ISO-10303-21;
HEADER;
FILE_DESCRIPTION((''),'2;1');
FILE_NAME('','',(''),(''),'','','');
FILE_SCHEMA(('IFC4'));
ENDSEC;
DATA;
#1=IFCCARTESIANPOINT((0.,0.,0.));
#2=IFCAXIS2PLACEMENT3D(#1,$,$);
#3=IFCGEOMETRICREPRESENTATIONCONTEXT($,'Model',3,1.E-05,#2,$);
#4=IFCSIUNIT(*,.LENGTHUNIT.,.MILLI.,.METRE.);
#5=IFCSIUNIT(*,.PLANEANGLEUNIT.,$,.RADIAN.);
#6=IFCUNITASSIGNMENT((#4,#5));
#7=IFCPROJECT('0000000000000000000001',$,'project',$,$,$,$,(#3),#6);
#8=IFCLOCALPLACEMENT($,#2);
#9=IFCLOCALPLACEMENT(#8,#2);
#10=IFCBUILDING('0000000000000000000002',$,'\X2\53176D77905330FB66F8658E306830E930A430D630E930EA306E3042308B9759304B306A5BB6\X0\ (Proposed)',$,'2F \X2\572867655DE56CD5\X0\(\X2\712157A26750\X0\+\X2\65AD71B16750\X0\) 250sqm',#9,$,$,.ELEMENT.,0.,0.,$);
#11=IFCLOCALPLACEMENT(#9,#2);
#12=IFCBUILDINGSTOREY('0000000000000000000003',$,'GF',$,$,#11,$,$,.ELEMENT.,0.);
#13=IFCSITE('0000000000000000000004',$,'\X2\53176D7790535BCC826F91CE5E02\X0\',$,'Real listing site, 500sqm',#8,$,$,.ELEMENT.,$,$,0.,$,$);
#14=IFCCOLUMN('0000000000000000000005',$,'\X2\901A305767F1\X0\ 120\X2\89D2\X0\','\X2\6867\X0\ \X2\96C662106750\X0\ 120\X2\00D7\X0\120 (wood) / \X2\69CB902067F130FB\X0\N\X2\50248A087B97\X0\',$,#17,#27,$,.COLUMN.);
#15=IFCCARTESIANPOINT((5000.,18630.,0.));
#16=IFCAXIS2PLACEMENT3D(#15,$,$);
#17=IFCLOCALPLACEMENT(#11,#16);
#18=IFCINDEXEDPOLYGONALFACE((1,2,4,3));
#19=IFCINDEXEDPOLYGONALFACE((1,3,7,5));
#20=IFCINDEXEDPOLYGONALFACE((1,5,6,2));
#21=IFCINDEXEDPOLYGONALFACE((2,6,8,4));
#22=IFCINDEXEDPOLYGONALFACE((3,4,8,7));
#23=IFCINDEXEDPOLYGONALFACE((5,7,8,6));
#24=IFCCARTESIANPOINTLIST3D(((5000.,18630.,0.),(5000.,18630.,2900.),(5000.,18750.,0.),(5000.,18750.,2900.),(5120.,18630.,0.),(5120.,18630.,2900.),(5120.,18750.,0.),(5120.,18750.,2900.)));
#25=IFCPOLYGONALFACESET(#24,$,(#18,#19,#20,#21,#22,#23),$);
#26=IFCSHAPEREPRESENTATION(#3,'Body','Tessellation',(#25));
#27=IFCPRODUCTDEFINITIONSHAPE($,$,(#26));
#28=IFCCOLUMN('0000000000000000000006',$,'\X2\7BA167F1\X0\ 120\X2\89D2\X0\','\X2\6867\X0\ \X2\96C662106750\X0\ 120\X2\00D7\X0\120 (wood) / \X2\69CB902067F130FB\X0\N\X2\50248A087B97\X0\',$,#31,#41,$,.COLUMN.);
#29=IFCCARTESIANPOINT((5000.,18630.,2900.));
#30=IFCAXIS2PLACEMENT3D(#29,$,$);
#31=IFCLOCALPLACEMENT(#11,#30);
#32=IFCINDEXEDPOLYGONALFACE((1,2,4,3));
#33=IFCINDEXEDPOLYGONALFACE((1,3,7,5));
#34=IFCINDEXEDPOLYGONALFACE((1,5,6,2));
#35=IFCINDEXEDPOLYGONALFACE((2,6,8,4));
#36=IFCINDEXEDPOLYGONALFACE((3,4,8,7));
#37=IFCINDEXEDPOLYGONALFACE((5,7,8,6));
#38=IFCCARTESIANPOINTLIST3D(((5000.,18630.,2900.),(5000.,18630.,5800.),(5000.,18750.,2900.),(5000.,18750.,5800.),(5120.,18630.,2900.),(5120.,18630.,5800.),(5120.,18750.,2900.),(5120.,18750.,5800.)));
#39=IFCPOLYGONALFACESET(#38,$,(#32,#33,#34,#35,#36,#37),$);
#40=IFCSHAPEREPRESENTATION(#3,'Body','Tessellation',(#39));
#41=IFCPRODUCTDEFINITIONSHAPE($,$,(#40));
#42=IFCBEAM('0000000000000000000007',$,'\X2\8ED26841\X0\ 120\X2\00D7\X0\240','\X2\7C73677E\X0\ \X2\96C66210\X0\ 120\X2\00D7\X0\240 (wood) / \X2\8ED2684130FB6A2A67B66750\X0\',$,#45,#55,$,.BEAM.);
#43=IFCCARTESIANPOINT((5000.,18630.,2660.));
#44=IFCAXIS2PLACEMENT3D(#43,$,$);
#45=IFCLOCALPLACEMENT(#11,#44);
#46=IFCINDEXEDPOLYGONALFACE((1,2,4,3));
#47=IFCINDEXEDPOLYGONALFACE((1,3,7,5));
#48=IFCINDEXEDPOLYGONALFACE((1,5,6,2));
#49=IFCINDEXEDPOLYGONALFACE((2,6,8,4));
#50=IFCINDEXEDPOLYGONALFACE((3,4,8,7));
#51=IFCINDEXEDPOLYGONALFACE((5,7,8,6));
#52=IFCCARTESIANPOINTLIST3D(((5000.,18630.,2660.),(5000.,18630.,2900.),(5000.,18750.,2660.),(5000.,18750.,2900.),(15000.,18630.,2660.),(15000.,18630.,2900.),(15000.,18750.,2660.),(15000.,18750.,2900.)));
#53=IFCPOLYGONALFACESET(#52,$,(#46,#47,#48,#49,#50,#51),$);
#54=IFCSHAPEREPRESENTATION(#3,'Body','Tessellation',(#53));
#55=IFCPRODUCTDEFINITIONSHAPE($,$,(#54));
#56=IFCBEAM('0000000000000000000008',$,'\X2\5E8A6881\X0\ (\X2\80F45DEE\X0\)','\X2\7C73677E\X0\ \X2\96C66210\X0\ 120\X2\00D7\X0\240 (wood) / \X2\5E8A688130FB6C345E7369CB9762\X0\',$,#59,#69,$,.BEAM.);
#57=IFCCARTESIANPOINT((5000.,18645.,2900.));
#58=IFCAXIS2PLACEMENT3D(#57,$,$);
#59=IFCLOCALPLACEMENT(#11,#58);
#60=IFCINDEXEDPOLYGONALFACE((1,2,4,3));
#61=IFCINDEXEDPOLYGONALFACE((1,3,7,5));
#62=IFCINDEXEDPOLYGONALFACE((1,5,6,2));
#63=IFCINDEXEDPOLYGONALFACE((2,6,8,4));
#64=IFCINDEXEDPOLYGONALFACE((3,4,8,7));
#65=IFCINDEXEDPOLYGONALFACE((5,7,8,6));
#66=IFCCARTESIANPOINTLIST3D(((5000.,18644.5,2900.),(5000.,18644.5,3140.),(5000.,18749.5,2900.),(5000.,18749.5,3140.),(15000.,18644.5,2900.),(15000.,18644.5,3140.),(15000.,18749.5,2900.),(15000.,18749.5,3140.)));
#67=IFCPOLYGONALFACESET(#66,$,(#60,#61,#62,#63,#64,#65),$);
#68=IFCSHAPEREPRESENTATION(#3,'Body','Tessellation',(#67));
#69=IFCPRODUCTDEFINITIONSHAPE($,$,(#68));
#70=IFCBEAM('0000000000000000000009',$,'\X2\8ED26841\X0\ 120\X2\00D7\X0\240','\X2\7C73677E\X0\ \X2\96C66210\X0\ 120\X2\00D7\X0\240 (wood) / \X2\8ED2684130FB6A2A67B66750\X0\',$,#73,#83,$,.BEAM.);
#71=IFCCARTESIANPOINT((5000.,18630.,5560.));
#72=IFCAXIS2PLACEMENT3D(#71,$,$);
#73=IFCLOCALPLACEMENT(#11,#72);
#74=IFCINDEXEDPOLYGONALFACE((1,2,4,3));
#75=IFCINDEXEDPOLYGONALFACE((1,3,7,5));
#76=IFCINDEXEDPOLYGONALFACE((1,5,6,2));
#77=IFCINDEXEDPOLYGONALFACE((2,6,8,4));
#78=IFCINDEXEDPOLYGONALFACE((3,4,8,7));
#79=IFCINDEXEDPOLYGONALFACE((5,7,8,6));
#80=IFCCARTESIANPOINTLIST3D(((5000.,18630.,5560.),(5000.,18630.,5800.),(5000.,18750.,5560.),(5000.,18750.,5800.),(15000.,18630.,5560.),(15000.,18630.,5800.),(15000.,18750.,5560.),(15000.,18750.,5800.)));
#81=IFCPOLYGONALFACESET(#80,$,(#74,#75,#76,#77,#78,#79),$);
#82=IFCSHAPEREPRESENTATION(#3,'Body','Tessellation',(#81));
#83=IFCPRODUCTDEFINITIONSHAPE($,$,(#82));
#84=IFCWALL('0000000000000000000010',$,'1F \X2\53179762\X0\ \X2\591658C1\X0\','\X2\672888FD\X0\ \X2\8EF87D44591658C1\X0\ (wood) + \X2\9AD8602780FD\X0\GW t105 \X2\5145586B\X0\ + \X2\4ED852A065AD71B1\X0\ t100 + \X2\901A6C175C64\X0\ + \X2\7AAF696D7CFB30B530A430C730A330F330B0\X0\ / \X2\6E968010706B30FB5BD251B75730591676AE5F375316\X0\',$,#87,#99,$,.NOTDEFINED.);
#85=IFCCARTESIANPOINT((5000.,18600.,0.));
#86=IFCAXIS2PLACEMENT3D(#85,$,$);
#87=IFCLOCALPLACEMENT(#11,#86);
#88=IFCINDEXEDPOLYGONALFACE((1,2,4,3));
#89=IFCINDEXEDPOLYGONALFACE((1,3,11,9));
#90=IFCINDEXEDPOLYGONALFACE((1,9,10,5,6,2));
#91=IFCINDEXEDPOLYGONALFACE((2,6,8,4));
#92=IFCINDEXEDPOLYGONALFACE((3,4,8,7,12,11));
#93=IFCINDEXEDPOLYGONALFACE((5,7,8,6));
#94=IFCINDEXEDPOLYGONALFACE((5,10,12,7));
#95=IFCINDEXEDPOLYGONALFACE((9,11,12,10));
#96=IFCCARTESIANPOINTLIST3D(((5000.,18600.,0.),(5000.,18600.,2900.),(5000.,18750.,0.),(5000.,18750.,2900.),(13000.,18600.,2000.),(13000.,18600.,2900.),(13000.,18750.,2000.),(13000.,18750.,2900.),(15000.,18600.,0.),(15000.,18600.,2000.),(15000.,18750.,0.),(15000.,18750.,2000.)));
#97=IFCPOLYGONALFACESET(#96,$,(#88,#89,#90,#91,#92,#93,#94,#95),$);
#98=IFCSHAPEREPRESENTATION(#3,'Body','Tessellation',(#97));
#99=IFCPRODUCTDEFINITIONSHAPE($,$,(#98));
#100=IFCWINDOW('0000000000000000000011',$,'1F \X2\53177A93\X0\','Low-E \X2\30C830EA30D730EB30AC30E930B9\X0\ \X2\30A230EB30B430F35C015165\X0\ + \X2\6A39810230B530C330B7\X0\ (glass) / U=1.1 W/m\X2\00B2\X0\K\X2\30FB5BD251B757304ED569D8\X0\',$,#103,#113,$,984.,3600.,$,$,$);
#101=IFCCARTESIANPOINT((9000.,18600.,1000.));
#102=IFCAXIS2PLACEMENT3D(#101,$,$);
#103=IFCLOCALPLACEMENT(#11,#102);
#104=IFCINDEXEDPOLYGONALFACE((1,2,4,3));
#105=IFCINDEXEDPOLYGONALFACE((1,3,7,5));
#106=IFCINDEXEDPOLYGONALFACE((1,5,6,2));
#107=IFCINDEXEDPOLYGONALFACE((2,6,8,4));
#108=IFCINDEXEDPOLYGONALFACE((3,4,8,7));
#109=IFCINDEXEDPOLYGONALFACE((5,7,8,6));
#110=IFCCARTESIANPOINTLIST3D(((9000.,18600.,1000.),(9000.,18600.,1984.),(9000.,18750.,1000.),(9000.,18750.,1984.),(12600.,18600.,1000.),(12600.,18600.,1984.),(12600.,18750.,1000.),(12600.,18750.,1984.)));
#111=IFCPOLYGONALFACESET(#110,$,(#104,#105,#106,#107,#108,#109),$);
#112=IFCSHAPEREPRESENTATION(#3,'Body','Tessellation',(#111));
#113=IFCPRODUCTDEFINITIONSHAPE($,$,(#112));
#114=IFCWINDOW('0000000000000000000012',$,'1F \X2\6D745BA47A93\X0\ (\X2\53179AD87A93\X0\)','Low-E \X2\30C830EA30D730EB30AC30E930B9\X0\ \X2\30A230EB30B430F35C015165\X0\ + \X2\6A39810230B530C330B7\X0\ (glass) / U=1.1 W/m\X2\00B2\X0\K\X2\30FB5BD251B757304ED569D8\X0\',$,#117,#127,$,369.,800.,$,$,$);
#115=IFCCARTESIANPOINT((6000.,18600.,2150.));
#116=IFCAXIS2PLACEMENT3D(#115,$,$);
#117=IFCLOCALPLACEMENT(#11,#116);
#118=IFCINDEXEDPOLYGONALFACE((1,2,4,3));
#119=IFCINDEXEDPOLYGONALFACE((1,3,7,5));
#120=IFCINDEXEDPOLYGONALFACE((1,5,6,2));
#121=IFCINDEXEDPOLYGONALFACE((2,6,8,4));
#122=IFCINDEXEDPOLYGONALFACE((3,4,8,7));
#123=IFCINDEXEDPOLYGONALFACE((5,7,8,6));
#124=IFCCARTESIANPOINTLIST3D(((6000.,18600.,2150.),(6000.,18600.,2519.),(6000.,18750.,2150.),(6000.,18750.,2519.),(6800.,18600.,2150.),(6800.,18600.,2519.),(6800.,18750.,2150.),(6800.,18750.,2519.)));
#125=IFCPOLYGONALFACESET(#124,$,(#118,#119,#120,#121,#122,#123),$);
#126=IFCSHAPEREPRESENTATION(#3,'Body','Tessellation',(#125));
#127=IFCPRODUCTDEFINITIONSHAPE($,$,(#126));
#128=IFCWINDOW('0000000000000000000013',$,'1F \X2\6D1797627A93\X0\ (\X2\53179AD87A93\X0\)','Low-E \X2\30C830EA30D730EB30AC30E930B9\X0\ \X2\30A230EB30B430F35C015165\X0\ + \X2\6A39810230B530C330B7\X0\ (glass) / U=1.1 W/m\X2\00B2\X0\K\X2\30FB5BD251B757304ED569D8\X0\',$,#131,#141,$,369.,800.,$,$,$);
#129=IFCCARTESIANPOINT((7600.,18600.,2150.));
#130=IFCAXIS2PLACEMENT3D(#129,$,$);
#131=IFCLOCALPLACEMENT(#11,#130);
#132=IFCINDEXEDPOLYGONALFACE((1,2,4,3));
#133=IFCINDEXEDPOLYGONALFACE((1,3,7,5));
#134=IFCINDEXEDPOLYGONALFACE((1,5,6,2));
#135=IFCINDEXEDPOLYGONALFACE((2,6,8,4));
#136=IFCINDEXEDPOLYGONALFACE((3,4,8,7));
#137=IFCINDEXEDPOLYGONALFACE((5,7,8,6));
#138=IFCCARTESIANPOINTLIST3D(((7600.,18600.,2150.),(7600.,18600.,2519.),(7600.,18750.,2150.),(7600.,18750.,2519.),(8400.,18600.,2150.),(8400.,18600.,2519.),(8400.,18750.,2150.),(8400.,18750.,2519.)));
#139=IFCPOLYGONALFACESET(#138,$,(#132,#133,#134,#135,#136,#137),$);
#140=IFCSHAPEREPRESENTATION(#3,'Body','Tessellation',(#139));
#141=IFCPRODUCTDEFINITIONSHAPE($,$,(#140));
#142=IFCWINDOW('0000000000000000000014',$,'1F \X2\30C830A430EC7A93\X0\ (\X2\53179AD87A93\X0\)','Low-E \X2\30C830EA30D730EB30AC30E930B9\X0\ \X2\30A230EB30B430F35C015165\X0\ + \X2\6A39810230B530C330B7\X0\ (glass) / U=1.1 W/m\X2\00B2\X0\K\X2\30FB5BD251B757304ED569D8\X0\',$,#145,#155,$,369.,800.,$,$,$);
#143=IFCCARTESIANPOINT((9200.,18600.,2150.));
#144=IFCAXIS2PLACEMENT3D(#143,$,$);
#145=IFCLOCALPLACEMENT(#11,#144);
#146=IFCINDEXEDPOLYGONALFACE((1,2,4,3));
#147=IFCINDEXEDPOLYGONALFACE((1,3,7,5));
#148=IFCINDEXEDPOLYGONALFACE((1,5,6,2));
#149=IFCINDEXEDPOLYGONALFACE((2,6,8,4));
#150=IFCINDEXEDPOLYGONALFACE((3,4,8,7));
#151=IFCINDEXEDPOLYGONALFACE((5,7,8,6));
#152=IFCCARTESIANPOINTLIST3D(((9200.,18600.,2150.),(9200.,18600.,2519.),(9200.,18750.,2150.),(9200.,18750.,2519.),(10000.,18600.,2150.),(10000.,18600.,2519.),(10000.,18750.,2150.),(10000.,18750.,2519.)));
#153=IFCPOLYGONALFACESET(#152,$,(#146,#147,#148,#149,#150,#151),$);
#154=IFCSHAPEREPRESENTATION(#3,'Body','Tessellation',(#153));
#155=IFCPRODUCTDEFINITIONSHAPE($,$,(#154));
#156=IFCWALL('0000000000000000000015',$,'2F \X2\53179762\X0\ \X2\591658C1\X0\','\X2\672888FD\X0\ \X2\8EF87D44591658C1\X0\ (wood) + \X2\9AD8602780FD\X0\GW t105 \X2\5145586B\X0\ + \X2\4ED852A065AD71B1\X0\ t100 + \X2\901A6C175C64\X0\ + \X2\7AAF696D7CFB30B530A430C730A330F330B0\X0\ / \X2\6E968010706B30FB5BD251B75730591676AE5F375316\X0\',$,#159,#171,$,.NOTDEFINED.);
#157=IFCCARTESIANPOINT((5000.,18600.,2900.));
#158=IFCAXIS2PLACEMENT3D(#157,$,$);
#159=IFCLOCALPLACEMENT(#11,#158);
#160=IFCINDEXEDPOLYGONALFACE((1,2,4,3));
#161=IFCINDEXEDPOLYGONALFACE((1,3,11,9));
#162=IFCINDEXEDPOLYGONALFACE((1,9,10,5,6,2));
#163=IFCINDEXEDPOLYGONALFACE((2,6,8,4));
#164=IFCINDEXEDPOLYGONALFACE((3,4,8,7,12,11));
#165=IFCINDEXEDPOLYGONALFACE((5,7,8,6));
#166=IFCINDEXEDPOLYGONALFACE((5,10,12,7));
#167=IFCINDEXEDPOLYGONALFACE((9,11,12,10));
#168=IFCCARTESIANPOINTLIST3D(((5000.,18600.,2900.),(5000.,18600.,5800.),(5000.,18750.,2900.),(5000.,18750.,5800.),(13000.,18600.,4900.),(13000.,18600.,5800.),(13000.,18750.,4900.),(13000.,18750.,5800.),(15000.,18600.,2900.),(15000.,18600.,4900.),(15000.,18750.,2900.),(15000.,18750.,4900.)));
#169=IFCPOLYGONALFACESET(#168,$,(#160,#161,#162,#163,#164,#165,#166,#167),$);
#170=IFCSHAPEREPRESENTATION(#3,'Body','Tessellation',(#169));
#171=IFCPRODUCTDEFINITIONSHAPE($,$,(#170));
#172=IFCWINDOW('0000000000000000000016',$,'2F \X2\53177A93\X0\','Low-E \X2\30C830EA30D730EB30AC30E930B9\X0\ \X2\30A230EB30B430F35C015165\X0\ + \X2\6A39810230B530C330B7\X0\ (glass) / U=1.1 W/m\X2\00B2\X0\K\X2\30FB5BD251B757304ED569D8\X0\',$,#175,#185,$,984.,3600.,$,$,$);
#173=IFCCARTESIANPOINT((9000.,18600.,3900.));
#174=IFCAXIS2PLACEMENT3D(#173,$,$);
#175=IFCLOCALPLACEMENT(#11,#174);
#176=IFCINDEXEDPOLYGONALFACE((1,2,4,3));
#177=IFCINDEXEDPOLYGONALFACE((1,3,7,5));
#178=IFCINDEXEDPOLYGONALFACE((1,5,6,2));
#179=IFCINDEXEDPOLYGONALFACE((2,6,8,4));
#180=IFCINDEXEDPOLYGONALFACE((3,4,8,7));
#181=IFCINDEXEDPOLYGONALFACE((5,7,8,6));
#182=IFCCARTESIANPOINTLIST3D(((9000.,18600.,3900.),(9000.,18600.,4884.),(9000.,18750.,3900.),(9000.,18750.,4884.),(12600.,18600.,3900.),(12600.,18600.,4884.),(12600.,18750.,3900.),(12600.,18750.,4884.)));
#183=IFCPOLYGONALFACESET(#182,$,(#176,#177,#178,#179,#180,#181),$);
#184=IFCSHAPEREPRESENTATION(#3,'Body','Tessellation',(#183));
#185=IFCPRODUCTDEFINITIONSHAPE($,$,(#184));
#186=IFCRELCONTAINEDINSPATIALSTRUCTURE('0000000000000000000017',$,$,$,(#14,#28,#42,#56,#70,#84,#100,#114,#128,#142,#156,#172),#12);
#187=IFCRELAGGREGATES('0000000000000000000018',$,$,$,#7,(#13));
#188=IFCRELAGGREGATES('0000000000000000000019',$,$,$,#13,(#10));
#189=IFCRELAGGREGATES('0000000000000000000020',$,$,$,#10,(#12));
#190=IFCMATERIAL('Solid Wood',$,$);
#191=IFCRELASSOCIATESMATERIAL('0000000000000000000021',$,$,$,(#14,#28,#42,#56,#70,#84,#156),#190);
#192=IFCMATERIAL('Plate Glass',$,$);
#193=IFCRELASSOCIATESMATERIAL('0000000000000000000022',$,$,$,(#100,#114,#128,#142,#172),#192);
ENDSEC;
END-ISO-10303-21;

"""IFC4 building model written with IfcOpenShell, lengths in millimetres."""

from ifc_helpers import new_model, si_unit, frame, frame_2d, origin, place, context, project, spatial, rectangle, extrude, material, element, fill, save


model = new_model("IFC4")

# Units and contexts
model_context = context("Model", 3, precision=1e-05, world=origin())
ifc_project = project(units=[si_unit("LENGTHUNIT", "METRE", prefix="MILLI"), si_unit("PLANEANGLEUNIT", "RADIAN")], contexts=[model_context])

# Site, building, storey
site_placement = place(None, origin())
site = spatial("IfcSite", under=ifc_project, at=site_placement, Name="北海道富良野市", ObjectType="Real listing site, 500sqm", CompositionType="ELEMENT", RefElevation=0.0)
building_placement = place(site_placement, origin())
building = spatial("IfcBuilding", under=site, at=building_placement, Name="北海道・書斎とライブラリのある静かな家 (Proposed)", ObjectType="2F 在来工法(無垢材+断熱材) 250sqm", CompositionType="ELEMENT", ElevationOfRefHeight=0.0, ElevationOfTerrain=0.0)
storey_placement = place(building_placement, origin())
storey = spatial("IfcBuildingStorey", under=building, at=storey_placement, Name="GF", CompositionType="ELEMENT", Elevation=0.0)

# Columns
ifc_material_1 = material(Name="Solid Wood")
column_1_placement = place(storey_placement, frame((5000.0, 18630.0, 0.0)))
element("IfcColumn", 1, at=column_1_placement, inside=storey, material=ifc_material_1, Name="通し柱 120角", Description="桧 集成材 120×120 (wood) / 構造柱・N値計算", PredefinedType="COLUMN", context=model_context, shape_type="SweptSolid", body=[
    extrude(rectangle(XDim=120.0, YDim=120.0, at=frame_2d((60.0, 60.0))), frame((5000.0, 18630.0, 0.0)), (0.0, 0.0, 1.0), 2900.0),
])
column_2_placement = place(storey_placement, frame((5000.0, 18630.0, 2900.0)))
element("IfcColumn", 2, at=column_2_placement, inside=storey, material=ifc_material_1, Name="管柱 120角", Description="桧 集成材 120×120 (wood) / 構造柱・N値計算", PredefinedType="COLUMN", context=model_context, shape_type="SweptSolid", body=[
    extrude(rectangle(XDim=120.0, YDim=120.0, at=frame_2d((60.0, 60.0))), frame((5000.0, 18630.0, 2900.0)), (0.0, 0.0, 1.0), 2900.0),
])

# Beams
beam_1_placement = place(storey_placement, frame((5000.0, 18630.0, 2660.0)))
element("IfcBeam", 3, at=beam_1_placement, inside=storey, material=ifc_material_1, Name="軒桁 120×240", Description="米松 集成 120×240 (wood) / 軒桁・横架材", PredefinedType="BEAM", context=model_context, shape_type="SweptSolid", body=[
    extrude(rectangle(XDim=10000.0, YDim=120.0, at=frame_2d((5000.0, 60.0))), frame((5000.0, 18630.0, 2660.0)), (0.0, 0.0, 1.0), 240.0),
])
beam_2_placement = place(storey_placement, frame((5000.0, 18645.0, 2900.0)))
element("IfcBeam", 4, at=beam_2_placement, inside=storey, material=ifc_material_1, Name="床梁 (胴差)", Description="米松 集成 120×240 (wood) / 床梁・水平構面", PredefinedType="BEAM", context=model_context, shape_type="SweptSolid", body=[
    extrude(rectangle(XDim=10000.0, YDim=105.0, at=frame_2d((5000.0, 52.0))), frame((5000.0, 18645.0, 2900.0)), (0.0, 0.0, 1.0), 240.0),
])
beam_3_placement = place(storey_placement, frame((5000.0, 18630.0, 5560.0)))
element("IfcBeam", 5, at=beam_3_placement, inside=storey, material=ifc_material_1, Name="軒桁 120×240", Description="米松 集成 120×240 (wood) / 軒桁・横架材", PredefinedType="BEAM", context=model_context, shape_type="SweptSolid", body=[
    extrude(rectangle(XDim=10000.0, YDim=120.0, at=frame_2d((5000.0, 60.0))), frame((5000.0, 18630.0, 5560.0)), (0.0, 0.0, 1.0), 240.0),
])

# Wall, openings, windows
wall_1_placement = place(storey_placement, frame((5000.0, 18600.0, 0.0)))
wall_1 = element("IfcWall", 6, at=wall_1_placement, inside=storey, material=ifc_material_1, Name="1F 北面 外壁", Description="木製 軸組外壁 (wood) + 高性能GW t105 充填 + 付加断熱 t100 + 通気層 + 窯業系サイディング / 準耐火・寒冷地外皮強化", PredefinedType="NOTDEFINED", context=model_context, shape_type="SweptSolid", body=[
    extrude(rectangle(XDim=10000.0, YDim=150.0, at=frame_2d((5000.0, 75.0))), frame((5000.0, 18600.0, 0.0)), (0.0, 0.0, 1.0), 2900.0),
])
opening_1_placement = place(storey_placement, frame((9000.0, 18600.0, 1000.0)))
opening_1 = element("IfcOpeningElement", 7, at=opening_1_placement, cuts=wall_1, PredefinedType="NOTDEFINED", context=model_context, shape_type="SweptSolid", body=[
    extrude(rectangle(XDim=3600.0, YDim=150.0, at=frame_2d((1800.0, 75.0))), frame((9000.0, 18600.0, 1000.0)), (0.0, 0.0, 1.0), 984.0),
])
opening_2_placement = place(storey_placement, frame((6000.0, 18600.0, 2150.0)))
opening_2 = element("IfcOpeningElement", 8, at=opening_2_placement, cuts=wall_1, PredefinedType="NOTDEFINED", context=model_context, shape_type="SweptSolid", body=[
    extrude(rectangle(XDim=800.0, YDim=150.0, at=frame_2d((400.0, 75.0))), frame((6000.0, 18600.0, 2150.0)), (0.0, 0.0, 1.0), 369.0),
])
opening_3_placement = place(storey_placement, frame((7600.0, 18600.0, 2150.0)))
opening_3 = element("IfcOpeningElement", 9, at=opening_3_placement, cuts=wall_1, PredefinedType="NOTDEFINED", context=model_context, shape_type="SweptSolid", body=[
    extrude(rectangle(XDim=800.0, YDim=150.0, at=frame_2d((400.0, 75.0))), frame((7600.0, 18600.0, 2150.0)), (0.0, 0.0, 1.0), 369.0),
])
opening_4_placement = place(storey_placement, frame((9200.0, 18600.0, 2150.0)))
opening_4 = element("IfcOpeningElement", 10, at=opening_4_placement, cuts=wall_1, PredefinedType="NOTDEFINED", context=model_context, shape_type="SweptSolid", body=[
    extrude(rectangle(XDim=800.0, YDim=150.0, at=frame_2d((400.0, 75.0))), frame((9200.0, 18600.0, 2150.0)), (0.0, 0.0, 1.0), 369.0),
])
ifc_material_2 = material(Name="Plate Glass")
window_1_placement = place(storey_placement, frame((9000.0, 18600.0, 1000.0)))
window_1 = element("IfcWindow", 11, at=window_1_placement, inside=storey, material=ifc_material_2, Name="1F 北窓", Description="Low-E トリプルガラス アルゴン封入 + 樹脂サッシ (glass) / U=1.1 W/m²K・寒冷地仕様", OverallHeight=984.0, OverallWidth=3600.0, context=model_context, shape_type="SweptSolid", body=[
    extrude(rectangle(XDim=3600.0, YDim=150.0, at=frame_2d((1800.0, 75.0))), frame((9000.0, 18600.0, 1000.0)), (0.0, 0.0, 1.0), 984.0),
])
fill(opening_1, window_1)
window_2_placement = place(storey_placement, frame((6000.0, 18600.0, 2150.0)))
window_2 = element("IfcWindow", 12, at=window_2_placement, inside=storey, material=ifc_material_2, Name="1F 浴室窓 (北高窓)", Description="Low-E トリプルガラス アルゴン封入 + 樹脂サッシ (glass) / U=1.1 W/m²K・寒冷地仕様", OverallHeight=369.0, OverallWidth=800.0, context=model_context, shape_type="SweptSolid", body=[
    extrude(rectangle(XDim=800.0, YDim=150.0, at=frame_2d((400.0, 75.0))), frame((6000.0, 18600.0, 2150.0)), (0.0, 0.0, 1.0), 369.0),
])
fill(opening_2, window_2)
window_3_placement = place(storey_placement, frame((7600.0, 18600.0, 2150.0)))
window_3 = element("IfcWindow", 13, at=window_3_placement, inside=storey, material=ifc_material_2, Name="1F 洗面窓 (北高窓)", Description="Low-E トリプルガラス アルゴン封入 + 樹脂サッシ (glass) / U=1.1 W/m²K・寒冷地仕様", OverallHeight=369.0, OverallWidth=800.0, context=model_context, shape_type="SweptSolid", body=[
    extrude(rectangle(XDim=800.0, YDim=150.0, at=frame_2d((400.0, 75.0))), frame((7600.0, 18600.0, 2150.0)), (0.0, 0.0, 1.0), 369.0),
])
fill(opening_3, window_3)
window_4_placement = place(storey_placement, frame((9200.0, 18600.0, 2150.0)))
window_4 = element("IfcWindow", 14, at=window_4_placement, inside=storey, material=ifc_material_2, Name="1F トイレ窓 (北高窓)", Description="Low-E トリプルガラス アルゴン封入 + 樹脂サッシ (glass) / U=1.1 W/m²K・寒冷地仕様", OverallHeight=369.0, OverallWidth=800.0, context=model_context, shape_type="SweptSolid", body=[
    extrude(rectangle(XDim=800.0, YDim=150.0, at=frame_2d((400.0, 75.0))), frame((9200.0, 18600.0, 2150.0)), (0.0, 0.0, 1.0), 369.0),
])
fill(opening_4, window_4)

# Wall, opening, window
wall_2_placement = place(storey_placement, frame((5000.0, 18600.0, 2900.0)))
wall_2 = element("IfcWall", 15, at=wall_2_placement, inside=storey, material=ifc_material_1, Name="2F 北面 外壁", Description="木製 軸組外壁 (wood) + 高性能GW t105 充填 + 付加断熱 t100 + 通気層 + 窯業系サイディング / 準耐火・寒冷地外皮強化", PredefinedType="NOTDEFINED", context=model_context, shape_type="SweptSolid", body=[
    extrude(rectangle(XDim=10000.0, YDim=150.0, at=frame_2d((5000.0, 75.0))), frame((5000.0, 18600.0, 2900.0)), (0.0, 0.0, 1.0), 2900.0),
])
opening_5_placement = place(storey_placement, frame((9000.0, 18600.0, 3900.0)))
opening_5 = element("IfcOpeningElement", 16, at=opening_5_placement, cuts=wall_2, PredefinedType="NOTDEFINED", context=model_context, shape_type="SweptSolid", body=[
    extrude(rectangle(XDim=3600.0, YDim=150.0, at=frame_2d((1800.0, 75.0))), frame((9000.0, 18600.0, 3900.0)), (0.0, 0.0, 1.0), 984.0),
])
window_5_placement = place(storey_placement, frame((9000.0, 18600.0, 3900.0)))
window_5 = element("IfcWindow", 17, at=window_5_placement, inside=storey, material=ifc_material_2, Name="2F 北窓", Description="Low-E トリプルガラス アルゴン封入 + 樹脂サッシ (glass) / U=1.1 W/m²K・寒冷地仕様", OverallHeight=984.0, OverallWidth=3600.0, context=model_context, shape_type="SweptSolid", body=[
    extrude(rectangle(XDim=3600.0, YDim=150.0, at=frame_2d((1800.0, 75.0))), frame((9000.0, 18600.0, 3900.0)), (0.0, 0.0, 1.0), 984.0),
])
fill(opening_5, window_5)

save(model, "model.ifc")
